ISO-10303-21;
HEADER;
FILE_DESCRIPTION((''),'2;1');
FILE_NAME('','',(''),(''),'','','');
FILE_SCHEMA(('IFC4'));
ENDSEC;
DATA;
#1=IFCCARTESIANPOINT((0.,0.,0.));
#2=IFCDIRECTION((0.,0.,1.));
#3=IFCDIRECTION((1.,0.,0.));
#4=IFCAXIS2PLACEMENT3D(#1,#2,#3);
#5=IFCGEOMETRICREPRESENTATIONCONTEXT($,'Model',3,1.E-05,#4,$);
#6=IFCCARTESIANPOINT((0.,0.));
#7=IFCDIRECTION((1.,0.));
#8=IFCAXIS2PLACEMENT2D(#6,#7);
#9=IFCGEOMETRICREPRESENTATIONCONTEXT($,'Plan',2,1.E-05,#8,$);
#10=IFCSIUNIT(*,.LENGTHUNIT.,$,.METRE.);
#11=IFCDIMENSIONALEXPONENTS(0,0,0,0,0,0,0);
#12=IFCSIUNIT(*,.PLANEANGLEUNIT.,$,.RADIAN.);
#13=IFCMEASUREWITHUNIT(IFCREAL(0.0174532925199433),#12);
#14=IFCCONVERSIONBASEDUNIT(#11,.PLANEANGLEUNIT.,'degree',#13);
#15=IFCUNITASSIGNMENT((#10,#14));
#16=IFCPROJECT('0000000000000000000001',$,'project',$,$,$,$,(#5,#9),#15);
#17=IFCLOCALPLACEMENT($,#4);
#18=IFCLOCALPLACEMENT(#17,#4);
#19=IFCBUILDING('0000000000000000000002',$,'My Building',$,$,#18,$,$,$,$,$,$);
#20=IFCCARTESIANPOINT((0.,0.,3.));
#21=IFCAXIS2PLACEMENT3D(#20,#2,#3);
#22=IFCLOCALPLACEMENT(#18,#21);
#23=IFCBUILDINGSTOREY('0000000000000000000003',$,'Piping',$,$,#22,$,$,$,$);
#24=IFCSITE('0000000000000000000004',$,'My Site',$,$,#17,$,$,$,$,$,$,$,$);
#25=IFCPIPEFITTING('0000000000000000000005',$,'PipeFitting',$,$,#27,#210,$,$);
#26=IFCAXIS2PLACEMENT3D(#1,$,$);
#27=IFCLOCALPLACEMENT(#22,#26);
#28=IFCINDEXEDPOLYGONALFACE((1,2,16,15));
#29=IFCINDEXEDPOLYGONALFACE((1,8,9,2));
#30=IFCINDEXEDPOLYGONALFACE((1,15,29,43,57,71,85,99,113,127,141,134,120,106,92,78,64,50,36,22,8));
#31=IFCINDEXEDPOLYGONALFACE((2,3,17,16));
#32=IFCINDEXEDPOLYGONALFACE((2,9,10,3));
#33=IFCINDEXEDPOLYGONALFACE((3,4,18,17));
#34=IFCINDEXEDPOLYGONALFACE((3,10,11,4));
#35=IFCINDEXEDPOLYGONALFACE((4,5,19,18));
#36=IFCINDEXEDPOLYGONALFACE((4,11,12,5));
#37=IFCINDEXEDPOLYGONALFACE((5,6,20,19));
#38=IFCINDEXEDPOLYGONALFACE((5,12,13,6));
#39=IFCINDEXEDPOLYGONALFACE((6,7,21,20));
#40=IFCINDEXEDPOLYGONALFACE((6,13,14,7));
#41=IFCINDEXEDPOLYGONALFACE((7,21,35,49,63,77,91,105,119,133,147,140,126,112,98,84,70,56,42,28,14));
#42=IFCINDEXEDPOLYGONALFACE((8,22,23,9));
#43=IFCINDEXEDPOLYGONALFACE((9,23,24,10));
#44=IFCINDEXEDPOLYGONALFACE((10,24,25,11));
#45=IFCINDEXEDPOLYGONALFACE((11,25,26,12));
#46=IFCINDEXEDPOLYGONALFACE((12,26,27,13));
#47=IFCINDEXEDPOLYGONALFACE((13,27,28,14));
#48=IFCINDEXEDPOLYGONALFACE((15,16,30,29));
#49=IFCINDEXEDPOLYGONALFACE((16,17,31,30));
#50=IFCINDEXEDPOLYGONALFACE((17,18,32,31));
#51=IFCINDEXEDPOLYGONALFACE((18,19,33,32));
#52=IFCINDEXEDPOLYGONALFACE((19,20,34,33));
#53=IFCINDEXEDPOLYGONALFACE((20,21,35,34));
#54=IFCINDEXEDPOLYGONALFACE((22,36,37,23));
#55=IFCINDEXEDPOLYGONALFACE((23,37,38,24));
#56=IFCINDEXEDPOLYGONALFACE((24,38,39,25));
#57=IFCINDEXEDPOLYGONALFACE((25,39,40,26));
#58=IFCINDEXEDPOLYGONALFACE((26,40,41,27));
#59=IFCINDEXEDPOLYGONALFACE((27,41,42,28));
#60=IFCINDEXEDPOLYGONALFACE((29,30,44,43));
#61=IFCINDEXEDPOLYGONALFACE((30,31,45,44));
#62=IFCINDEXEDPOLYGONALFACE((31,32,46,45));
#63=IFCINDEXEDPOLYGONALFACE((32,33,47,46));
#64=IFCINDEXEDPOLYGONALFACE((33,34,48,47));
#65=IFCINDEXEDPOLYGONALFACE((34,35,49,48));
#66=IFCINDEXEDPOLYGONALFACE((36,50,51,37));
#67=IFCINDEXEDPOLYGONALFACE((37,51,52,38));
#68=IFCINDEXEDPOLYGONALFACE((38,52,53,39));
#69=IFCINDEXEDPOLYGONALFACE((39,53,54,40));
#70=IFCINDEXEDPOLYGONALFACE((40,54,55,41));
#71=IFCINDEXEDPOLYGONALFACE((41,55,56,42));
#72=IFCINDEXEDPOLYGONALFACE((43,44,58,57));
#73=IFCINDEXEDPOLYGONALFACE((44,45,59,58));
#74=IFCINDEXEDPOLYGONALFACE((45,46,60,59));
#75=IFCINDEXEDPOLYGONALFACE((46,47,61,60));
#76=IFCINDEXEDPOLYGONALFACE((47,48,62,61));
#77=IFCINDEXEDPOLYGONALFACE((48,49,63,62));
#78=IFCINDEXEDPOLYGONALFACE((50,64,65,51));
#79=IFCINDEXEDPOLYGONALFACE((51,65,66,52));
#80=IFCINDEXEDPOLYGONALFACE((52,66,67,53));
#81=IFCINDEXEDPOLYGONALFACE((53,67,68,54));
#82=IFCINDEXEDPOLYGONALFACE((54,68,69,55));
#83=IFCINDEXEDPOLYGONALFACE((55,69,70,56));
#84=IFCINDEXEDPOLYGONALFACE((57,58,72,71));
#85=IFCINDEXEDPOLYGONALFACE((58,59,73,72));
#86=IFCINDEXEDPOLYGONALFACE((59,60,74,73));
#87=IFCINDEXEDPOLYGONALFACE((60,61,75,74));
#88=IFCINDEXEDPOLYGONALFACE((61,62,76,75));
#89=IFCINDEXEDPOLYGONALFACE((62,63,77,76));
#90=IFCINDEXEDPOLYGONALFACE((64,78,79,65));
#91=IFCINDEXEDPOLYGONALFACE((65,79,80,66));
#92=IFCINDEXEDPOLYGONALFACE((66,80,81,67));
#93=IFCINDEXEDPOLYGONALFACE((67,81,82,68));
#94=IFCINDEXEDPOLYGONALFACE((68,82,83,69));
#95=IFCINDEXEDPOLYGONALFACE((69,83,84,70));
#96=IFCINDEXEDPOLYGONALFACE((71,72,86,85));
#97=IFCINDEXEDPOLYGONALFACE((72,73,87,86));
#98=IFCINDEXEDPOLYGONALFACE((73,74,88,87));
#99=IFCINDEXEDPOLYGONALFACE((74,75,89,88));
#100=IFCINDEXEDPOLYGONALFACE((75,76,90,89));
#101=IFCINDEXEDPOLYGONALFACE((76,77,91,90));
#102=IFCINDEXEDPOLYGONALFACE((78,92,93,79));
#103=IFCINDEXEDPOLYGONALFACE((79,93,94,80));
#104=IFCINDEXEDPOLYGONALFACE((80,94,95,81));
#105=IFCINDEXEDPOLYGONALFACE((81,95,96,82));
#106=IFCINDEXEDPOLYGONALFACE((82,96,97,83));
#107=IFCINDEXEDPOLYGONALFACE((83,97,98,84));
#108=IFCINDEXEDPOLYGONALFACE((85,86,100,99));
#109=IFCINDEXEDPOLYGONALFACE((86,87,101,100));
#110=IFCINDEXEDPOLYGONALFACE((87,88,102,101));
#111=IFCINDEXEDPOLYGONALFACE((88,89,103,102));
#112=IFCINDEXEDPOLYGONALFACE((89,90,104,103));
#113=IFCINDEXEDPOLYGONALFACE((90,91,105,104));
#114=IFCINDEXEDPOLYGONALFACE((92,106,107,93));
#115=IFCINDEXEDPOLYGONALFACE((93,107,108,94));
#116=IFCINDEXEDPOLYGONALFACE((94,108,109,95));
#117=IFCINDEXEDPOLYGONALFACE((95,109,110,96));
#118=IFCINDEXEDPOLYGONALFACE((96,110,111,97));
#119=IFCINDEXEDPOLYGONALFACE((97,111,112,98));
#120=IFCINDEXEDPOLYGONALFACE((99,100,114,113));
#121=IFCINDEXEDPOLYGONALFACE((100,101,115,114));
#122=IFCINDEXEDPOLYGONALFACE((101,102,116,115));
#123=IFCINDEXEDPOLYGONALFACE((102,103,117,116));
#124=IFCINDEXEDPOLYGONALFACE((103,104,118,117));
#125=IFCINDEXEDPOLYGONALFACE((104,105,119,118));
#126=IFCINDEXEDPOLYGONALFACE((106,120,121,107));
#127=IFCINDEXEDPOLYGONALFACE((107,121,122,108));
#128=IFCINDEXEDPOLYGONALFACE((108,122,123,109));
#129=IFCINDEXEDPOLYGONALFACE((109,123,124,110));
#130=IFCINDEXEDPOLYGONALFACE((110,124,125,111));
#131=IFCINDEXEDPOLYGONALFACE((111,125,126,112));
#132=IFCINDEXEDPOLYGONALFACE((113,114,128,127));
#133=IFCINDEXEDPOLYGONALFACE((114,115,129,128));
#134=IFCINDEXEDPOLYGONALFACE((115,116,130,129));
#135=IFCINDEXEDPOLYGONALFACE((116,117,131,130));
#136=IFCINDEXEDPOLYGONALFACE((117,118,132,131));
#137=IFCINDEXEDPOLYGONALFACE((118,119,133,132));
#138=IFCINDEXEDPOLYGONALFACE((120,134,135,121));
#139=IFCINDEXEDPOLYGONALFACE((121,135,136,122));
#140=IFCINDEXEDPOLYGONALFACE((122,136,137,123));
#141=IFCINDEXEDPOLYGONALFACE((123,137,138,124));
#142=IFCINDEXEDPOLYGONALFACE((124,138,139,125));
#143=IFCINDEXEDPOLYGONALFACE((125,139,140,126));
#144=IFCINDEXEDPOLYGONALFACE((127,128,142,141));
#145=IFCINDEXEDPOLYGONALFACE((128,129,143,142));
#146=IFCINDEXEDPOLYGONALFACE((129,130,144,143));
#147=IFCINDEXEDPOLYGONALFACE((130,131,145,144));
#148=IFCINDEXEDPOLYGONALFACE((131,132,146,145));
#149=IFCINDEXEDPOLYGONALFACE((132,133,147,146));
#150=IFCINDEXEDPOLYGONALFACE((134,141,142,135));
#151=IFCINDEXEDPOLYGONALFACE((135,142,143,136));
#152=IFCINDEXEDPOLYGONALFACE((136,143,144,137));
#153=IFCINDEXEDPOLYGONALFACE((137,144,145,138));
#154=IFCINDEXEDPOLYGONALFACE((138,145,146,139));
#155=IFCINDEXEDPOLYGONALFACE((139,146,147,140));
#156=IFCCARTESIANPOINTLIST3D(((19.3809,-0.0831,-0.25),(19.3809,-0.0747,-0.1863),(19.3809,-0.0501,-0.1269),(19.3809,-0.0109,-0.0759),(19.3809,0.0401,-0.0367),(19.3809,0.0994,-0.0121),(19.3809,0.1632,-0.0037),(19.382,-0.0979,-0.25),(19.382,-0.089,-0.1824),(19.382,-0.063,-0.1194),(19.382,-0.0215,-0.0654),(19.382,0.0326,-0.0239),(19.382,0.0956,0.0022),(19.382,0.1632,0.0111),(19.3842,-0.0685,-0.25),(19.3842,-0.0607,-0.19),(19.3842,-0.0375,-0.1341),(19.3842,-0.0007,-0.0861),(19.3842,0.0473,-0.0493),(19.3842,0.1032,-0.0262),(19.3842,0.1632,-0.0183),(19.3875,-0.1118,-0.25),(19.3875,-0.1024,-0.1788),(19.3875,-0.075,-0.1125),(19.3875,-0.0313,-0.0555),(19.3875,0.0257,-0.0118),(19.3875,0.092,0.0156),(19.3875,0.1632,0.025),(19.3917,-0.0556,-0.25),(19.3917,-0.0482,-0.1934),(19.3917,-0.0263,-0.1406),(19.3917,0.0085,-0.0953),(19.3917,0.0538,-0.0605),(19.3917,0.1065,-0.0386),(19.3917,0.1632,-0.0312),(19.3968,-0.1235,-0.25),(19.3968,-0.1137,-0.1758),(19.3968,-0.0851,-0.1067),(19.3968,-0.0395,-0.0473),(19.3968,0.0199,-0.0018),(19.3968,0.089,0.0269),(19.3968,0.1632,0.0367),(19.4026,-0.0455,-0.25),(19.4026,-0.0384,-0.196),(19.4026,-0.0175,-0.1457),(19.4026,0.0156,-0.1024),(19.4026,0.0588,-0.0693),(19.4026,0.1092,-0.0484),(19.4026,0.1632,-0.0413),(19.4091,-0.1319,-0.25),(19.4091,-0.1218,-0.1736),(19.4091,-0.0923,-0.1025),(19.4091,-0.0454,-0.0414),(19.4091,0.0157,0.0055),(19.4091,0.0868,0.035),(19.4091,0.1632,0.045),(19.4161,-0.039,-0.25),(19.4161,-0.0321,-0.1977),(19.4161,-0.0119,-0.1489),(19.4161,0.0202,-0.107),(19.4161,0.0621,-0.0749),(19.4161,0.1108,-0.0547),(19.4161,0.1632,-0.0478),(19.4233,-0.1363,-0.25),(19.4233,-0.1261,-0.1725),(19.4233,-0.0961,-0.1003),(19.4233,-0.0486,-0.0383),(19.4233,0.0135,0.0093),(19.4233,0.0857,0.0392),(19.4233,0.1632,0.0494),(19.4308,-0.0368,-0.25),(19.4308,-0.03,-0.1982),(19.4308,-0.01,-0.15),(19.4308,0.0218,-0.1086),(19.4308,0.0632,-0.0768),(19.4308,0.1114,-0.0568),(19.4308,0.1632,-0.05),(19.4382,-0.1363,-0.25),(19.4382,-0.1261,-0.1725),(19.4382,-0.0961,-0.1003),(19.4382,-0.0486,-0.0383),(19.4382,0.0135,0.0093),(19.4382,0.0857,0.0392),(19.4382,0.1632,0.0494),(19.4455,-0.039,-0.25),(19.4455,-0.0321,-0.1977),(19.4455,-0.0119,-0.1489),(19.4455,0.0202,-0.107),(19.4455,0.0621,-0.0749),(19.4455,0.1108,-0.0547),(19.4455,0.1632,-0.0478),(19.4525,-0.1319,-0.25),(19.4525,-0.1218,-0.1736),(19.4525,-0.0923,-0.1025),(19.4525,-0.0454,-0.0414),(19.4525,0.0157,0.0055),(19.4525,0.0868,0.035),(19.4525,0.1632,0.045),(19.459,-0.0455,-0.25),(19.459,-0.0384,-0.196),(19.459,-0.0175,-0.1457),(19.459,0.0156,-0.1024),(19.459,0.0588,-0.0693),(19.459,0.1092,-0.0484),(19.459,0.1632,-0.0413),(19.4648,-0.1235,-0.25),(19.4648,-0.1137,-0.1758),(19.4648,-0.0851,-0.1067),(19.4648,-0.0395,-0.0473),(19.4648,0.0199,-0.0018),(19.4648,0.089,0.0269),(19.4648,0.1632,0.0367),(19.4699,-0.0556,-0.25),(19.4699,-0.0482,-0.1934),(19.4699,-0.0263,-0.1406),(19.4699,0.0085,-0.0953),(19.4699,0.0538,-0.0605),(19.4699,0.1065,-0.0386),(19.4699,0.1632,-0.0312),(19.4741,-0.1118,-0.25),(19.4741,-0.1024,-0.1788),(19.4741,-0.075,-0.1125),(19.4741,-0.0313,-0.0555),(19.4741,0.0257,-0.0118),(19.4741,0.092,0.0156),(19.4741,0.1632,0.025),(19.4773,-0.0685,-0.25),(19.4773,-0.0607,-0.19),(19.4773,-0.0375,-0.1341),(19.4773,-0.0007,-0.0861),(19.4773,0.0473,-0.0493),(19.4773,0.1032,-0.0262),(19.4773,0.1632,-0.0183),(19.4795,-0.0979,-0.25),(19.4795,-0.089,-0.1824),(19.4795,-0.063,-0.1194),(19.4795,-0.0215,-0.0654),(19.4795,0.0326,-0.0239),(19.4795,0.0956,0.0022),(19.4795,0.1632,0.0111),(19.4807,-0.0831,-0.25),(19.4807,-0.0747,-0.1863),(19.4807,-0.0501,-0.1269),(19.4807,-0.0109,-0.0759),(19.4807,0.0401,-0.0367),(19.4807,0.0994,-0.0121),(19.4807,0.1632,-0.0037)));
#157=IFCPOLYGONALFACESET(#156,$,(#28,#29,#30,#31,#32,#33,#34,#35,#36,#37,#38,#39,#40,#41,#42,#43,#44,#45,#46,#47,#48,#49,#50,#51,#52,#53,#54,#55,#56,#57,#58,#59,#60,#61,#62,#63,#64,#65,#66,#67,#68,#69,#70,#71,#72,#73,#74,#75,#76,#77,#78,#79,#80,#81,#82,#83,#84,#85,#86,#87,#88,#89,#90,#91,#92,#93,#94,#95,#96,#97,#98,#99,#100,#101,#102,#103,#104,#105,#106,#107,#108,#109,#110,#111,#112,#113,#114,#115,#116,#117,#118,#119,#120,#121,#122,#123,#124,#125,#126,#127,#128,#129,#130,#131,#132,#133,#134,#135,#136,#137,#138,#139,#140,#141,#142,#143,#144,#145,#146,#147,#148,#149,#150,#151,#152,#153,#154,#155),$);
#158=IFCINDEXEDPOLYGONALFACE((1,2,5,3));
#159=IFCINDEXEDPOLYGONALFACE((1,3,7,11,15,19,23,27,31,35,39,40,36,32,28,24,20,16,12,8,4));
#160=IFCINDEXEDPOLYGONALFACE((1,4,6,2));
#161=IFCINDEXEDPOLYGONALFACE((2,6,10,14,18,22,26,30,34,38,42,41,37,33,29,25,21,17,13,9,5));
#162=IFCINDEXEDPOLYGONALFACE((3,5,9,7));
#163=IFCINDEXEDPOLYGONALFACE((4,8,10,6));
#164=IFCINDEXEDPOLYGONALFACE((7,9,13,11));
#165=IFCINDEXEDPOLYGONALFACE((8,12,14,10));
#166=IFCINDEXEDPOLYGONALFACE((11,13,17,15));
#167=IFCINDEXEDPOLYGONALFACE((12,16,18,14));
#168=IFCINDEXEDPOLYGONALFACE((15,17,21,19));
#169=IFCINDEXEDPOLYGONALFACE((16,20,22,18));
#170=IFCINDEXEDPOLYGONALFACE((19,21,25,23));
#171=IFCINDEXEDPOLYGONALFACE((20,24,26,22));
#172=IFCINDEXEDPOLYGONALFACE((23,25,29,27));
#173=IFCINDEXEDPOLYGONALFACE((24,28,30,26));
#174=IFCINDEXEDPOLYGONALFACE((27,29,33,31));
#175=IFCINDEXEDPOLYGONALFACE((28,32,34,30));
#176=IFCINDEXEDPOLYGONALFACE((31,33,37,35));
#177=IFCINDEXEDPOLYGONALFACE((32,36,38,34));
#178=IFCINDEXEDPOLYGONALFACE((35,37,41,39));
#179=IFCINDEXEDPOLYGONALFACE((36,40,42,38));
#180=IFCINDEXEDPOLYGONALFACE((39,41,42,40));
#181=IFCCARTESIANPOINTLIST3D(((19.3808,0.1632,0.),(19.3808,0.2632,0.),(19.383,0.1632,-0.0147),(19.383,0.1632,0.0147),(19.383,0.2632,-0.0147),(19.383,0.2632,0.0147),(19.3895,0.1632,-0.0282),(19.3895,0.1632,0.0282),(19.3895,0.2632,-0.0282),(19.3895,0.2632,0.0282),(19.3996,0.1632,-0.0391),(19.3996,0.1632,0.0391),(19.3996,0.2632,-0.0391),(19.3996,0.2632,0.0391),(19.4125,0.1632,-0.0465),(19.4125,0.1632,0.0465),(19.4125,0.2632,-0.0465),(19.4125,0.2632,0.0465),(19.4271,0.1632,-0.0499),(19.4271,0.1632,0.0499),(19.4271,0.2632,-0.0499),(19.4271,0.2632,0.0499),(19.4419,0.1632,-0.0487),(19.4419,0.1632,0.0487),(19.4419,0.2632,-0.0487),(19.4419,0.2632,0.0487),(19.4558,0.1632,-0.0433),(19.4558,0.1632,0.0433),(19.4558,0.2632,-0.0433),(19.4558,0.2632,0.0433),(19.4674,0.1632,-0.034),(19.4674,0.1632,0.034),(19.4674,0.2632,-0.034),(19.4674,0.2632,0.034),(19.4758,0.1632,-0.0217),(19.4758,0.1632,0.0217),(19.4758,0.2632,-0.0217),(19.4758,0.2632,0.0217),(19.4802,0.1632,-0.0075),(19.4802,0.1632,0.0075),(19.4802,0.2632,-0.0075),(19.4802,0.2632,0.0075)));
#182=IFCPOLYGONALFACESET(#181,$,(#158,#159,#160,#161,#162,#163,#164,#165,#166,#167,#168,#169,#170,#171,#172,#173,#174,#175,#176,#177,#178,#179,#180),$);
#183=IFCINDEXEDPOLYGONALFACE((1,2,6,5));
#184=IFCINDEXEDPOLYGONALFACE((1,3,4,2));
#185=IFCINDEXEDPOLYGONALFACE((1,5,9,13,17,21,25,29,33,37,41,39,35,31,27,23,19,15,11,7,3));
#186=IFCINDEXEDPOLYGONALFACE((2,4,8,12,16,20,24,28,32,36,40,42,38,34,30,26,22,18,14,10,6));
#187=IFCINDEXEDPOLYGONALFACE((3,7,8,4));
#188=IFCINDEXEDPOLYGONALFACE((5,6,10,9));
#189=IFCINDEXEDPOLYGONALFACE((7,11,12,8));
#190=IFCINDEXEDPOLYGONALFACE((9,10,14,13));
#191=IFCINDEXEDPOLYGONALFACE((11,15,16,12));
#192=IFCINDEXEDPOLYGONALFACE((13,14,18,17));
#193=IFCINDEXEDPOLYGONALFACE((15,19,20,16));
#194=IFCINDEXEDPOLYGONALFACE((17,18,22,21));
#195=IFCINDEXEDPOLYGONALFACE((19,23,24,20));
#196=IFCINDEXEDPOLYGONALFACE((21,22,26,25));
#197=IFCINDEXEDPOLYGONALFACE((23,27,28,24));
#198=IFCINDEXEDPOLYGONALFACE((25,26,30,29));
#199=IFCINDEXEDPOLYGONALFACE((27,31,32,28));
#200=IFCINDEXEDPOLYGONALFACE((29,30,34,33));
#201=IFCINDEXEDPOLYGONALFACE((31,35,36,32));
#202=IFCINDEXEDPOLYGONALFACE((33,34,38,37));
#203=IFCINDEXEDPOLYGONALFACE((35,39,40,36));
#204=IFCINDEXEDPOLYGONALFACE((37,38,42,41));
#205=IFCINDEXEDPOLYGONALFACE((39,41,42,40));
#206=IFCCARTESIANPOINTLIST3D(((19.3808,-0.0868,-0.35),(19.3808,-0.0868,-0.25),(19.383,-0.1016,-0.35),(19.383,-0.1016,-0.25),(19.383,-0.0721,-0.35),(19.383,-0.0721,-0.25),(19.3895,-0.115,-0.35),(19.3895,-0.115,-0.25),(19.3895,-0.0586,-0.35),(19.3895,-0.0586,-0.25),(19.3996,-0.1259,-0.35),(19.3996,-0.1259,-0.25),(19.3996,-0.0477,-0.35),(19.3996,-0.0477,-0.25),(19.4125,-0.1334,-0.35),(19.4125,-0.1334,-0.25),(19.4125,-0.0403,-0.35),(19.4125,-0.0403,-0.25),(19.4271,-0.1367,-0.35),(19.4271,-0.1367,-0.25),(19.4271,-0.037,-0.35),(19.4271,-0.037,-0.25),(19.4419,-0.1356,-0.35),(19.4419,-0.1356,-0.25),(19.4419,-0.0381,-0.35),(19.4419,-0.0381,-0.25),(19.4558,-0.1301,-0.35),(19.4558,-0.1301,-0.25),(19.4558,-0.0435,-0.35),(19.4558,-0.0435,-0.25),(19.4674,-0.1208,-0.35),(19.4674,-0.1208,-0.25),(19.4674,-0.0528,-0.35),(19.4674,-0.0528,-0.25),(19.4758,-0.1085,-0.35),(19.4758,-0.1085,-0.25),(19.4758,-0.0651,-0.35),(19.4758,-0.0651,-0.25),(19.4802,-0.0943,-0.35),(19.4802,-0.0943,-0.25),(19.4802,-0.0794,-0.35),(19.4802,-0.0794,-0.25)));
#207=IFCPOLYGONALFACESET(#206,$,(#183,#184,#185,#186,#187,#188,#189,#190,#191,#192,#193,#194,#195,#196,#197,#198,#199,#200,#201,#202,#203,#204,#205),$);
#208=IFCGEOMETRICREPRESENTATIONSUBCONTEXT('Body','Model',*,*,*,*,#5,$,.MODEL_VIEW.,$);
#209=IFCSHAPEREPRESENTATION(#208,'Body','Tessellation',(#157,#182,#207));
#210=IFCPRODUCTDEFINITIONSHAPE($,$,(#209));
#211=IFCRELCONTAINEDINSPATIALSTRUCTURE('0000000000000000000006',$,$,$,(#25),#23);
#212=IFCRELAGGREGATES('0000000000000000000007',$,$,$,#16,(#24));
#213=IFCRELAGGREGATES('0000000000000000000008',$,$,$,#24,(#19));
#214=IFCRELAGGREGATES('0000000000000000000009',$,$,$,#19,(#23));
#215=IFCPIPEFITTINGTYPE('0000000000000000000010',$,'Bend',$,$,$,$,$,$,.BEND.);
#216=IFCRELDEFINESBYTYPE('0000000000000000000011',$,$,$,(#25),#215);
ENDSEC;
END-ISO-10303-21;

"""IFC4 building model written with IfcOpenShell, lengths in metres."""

from ifc_helpers import new_model, entity, si_unit, converted_unit, frame, origin_with_axes, origin_2d_with_axis, place, context, subcontext, project, spatial, circle, extrude, source, transform, mapped, type_object, type_shapes, element, save


model = new_model("IFC4")

# Units and contexts
model_context = context("Model", 3, precision=1e-05, world=origin_with_axes())
plan_context = context("Plan", 2, precision=1e-05, world=origin_2d_with_axis())
body_context = subcontext(model_context, "Body", "Model", "MODEL_VIEW")
ifc_project = project(units=[si_unit("LENGTHUNIT", "METRE"), converted_unit("PLANEANGLEUNIT", "degree", entity("IfcReal", 0.0174532925199433), si_unit("PLANEANGLEUNIT", "RADIAN"), dimensions=[0, 0, 0, 0, 0, 0, 0])], contexts=[model_context, plan_context])

# Site, building, storey
site_placement = place(None, origin_with_axes())
site = spatial("IfcSite", under=ifc_project, at=site_placement, Name="My Site")
building_placement = place(site_placement, origin_with_axes())
building = spatial("IfcBuilding", under=site, at=building_placement, Name="My Building")
storey_placement = place(building_placement, frame((0.0, 0.0, 3.0), z_axis=(0.0, 0.0, 1.0), x_axis=(1.0, 0.0, 0.0)))
storey = spatial("IfcBuildingStorey", under=building, at=storey_placement, Name="Piping")

# Pipe fitting
pipe_fitting_type_1 = type_object("IfcPipeFittingType", Name="Bend", PredefinedType="BEND")
shared_shape = source(origin_with_axes(), body_context, "Body", "SolidModel", [
    entity("IfcSweptDiskSolid", entity("IfcIndexedPolyCurve", entity("IfcCartesianPointList3D", [[0.0, 0.0, -0.1], [0.0, -0.0732, -0.2768], [0.0, -0.25, -0.35]]), [entity("IfcArcIndex", [1, 2, 3])]), 0.05),
    extrude(circle(Radius=0.05), origin_with_axes(), (0.0, 0.0, -1.0), 0.1),
    extrude(circle(Radius=0.05), frame((0.0, -0.25, -0.35), z_axis=(0.0, -1.0, 0.0), x_axis=(1.0, 0.0, 0.0)), (0.0, 0.0, 1.0), 0.1),
])
type_shapes(pipe_fitting_type_1, [shared_shape])
for number, where, z_axis, x_axis, name in (
    (1, (19.4308, 0.2632, 0.0), (0.0, 1.0, 0.0), (-1.0, 0.0, 0.0), "PipeFitting"),
):
    element("IfcPipeFitting", number, at=place(storey_placement, frame(where, z_axis=z_axis, x_axis=x_axis)), inside=storey, type_object=pipe_fitting_type_1, Name=name, context=body_context, shape_type="MappedRepresentation", body=[
        mapped(shared_shape, transform((0.0, 0.0, 0.0), x_axis=(1.0, 0.0, 0.0), y_axis=(0.0, 1.0, 0.0), z_axis=(0.0, 0.0, 1.0), scale=1.0)),
    ])

save(model, "model.ifc")
